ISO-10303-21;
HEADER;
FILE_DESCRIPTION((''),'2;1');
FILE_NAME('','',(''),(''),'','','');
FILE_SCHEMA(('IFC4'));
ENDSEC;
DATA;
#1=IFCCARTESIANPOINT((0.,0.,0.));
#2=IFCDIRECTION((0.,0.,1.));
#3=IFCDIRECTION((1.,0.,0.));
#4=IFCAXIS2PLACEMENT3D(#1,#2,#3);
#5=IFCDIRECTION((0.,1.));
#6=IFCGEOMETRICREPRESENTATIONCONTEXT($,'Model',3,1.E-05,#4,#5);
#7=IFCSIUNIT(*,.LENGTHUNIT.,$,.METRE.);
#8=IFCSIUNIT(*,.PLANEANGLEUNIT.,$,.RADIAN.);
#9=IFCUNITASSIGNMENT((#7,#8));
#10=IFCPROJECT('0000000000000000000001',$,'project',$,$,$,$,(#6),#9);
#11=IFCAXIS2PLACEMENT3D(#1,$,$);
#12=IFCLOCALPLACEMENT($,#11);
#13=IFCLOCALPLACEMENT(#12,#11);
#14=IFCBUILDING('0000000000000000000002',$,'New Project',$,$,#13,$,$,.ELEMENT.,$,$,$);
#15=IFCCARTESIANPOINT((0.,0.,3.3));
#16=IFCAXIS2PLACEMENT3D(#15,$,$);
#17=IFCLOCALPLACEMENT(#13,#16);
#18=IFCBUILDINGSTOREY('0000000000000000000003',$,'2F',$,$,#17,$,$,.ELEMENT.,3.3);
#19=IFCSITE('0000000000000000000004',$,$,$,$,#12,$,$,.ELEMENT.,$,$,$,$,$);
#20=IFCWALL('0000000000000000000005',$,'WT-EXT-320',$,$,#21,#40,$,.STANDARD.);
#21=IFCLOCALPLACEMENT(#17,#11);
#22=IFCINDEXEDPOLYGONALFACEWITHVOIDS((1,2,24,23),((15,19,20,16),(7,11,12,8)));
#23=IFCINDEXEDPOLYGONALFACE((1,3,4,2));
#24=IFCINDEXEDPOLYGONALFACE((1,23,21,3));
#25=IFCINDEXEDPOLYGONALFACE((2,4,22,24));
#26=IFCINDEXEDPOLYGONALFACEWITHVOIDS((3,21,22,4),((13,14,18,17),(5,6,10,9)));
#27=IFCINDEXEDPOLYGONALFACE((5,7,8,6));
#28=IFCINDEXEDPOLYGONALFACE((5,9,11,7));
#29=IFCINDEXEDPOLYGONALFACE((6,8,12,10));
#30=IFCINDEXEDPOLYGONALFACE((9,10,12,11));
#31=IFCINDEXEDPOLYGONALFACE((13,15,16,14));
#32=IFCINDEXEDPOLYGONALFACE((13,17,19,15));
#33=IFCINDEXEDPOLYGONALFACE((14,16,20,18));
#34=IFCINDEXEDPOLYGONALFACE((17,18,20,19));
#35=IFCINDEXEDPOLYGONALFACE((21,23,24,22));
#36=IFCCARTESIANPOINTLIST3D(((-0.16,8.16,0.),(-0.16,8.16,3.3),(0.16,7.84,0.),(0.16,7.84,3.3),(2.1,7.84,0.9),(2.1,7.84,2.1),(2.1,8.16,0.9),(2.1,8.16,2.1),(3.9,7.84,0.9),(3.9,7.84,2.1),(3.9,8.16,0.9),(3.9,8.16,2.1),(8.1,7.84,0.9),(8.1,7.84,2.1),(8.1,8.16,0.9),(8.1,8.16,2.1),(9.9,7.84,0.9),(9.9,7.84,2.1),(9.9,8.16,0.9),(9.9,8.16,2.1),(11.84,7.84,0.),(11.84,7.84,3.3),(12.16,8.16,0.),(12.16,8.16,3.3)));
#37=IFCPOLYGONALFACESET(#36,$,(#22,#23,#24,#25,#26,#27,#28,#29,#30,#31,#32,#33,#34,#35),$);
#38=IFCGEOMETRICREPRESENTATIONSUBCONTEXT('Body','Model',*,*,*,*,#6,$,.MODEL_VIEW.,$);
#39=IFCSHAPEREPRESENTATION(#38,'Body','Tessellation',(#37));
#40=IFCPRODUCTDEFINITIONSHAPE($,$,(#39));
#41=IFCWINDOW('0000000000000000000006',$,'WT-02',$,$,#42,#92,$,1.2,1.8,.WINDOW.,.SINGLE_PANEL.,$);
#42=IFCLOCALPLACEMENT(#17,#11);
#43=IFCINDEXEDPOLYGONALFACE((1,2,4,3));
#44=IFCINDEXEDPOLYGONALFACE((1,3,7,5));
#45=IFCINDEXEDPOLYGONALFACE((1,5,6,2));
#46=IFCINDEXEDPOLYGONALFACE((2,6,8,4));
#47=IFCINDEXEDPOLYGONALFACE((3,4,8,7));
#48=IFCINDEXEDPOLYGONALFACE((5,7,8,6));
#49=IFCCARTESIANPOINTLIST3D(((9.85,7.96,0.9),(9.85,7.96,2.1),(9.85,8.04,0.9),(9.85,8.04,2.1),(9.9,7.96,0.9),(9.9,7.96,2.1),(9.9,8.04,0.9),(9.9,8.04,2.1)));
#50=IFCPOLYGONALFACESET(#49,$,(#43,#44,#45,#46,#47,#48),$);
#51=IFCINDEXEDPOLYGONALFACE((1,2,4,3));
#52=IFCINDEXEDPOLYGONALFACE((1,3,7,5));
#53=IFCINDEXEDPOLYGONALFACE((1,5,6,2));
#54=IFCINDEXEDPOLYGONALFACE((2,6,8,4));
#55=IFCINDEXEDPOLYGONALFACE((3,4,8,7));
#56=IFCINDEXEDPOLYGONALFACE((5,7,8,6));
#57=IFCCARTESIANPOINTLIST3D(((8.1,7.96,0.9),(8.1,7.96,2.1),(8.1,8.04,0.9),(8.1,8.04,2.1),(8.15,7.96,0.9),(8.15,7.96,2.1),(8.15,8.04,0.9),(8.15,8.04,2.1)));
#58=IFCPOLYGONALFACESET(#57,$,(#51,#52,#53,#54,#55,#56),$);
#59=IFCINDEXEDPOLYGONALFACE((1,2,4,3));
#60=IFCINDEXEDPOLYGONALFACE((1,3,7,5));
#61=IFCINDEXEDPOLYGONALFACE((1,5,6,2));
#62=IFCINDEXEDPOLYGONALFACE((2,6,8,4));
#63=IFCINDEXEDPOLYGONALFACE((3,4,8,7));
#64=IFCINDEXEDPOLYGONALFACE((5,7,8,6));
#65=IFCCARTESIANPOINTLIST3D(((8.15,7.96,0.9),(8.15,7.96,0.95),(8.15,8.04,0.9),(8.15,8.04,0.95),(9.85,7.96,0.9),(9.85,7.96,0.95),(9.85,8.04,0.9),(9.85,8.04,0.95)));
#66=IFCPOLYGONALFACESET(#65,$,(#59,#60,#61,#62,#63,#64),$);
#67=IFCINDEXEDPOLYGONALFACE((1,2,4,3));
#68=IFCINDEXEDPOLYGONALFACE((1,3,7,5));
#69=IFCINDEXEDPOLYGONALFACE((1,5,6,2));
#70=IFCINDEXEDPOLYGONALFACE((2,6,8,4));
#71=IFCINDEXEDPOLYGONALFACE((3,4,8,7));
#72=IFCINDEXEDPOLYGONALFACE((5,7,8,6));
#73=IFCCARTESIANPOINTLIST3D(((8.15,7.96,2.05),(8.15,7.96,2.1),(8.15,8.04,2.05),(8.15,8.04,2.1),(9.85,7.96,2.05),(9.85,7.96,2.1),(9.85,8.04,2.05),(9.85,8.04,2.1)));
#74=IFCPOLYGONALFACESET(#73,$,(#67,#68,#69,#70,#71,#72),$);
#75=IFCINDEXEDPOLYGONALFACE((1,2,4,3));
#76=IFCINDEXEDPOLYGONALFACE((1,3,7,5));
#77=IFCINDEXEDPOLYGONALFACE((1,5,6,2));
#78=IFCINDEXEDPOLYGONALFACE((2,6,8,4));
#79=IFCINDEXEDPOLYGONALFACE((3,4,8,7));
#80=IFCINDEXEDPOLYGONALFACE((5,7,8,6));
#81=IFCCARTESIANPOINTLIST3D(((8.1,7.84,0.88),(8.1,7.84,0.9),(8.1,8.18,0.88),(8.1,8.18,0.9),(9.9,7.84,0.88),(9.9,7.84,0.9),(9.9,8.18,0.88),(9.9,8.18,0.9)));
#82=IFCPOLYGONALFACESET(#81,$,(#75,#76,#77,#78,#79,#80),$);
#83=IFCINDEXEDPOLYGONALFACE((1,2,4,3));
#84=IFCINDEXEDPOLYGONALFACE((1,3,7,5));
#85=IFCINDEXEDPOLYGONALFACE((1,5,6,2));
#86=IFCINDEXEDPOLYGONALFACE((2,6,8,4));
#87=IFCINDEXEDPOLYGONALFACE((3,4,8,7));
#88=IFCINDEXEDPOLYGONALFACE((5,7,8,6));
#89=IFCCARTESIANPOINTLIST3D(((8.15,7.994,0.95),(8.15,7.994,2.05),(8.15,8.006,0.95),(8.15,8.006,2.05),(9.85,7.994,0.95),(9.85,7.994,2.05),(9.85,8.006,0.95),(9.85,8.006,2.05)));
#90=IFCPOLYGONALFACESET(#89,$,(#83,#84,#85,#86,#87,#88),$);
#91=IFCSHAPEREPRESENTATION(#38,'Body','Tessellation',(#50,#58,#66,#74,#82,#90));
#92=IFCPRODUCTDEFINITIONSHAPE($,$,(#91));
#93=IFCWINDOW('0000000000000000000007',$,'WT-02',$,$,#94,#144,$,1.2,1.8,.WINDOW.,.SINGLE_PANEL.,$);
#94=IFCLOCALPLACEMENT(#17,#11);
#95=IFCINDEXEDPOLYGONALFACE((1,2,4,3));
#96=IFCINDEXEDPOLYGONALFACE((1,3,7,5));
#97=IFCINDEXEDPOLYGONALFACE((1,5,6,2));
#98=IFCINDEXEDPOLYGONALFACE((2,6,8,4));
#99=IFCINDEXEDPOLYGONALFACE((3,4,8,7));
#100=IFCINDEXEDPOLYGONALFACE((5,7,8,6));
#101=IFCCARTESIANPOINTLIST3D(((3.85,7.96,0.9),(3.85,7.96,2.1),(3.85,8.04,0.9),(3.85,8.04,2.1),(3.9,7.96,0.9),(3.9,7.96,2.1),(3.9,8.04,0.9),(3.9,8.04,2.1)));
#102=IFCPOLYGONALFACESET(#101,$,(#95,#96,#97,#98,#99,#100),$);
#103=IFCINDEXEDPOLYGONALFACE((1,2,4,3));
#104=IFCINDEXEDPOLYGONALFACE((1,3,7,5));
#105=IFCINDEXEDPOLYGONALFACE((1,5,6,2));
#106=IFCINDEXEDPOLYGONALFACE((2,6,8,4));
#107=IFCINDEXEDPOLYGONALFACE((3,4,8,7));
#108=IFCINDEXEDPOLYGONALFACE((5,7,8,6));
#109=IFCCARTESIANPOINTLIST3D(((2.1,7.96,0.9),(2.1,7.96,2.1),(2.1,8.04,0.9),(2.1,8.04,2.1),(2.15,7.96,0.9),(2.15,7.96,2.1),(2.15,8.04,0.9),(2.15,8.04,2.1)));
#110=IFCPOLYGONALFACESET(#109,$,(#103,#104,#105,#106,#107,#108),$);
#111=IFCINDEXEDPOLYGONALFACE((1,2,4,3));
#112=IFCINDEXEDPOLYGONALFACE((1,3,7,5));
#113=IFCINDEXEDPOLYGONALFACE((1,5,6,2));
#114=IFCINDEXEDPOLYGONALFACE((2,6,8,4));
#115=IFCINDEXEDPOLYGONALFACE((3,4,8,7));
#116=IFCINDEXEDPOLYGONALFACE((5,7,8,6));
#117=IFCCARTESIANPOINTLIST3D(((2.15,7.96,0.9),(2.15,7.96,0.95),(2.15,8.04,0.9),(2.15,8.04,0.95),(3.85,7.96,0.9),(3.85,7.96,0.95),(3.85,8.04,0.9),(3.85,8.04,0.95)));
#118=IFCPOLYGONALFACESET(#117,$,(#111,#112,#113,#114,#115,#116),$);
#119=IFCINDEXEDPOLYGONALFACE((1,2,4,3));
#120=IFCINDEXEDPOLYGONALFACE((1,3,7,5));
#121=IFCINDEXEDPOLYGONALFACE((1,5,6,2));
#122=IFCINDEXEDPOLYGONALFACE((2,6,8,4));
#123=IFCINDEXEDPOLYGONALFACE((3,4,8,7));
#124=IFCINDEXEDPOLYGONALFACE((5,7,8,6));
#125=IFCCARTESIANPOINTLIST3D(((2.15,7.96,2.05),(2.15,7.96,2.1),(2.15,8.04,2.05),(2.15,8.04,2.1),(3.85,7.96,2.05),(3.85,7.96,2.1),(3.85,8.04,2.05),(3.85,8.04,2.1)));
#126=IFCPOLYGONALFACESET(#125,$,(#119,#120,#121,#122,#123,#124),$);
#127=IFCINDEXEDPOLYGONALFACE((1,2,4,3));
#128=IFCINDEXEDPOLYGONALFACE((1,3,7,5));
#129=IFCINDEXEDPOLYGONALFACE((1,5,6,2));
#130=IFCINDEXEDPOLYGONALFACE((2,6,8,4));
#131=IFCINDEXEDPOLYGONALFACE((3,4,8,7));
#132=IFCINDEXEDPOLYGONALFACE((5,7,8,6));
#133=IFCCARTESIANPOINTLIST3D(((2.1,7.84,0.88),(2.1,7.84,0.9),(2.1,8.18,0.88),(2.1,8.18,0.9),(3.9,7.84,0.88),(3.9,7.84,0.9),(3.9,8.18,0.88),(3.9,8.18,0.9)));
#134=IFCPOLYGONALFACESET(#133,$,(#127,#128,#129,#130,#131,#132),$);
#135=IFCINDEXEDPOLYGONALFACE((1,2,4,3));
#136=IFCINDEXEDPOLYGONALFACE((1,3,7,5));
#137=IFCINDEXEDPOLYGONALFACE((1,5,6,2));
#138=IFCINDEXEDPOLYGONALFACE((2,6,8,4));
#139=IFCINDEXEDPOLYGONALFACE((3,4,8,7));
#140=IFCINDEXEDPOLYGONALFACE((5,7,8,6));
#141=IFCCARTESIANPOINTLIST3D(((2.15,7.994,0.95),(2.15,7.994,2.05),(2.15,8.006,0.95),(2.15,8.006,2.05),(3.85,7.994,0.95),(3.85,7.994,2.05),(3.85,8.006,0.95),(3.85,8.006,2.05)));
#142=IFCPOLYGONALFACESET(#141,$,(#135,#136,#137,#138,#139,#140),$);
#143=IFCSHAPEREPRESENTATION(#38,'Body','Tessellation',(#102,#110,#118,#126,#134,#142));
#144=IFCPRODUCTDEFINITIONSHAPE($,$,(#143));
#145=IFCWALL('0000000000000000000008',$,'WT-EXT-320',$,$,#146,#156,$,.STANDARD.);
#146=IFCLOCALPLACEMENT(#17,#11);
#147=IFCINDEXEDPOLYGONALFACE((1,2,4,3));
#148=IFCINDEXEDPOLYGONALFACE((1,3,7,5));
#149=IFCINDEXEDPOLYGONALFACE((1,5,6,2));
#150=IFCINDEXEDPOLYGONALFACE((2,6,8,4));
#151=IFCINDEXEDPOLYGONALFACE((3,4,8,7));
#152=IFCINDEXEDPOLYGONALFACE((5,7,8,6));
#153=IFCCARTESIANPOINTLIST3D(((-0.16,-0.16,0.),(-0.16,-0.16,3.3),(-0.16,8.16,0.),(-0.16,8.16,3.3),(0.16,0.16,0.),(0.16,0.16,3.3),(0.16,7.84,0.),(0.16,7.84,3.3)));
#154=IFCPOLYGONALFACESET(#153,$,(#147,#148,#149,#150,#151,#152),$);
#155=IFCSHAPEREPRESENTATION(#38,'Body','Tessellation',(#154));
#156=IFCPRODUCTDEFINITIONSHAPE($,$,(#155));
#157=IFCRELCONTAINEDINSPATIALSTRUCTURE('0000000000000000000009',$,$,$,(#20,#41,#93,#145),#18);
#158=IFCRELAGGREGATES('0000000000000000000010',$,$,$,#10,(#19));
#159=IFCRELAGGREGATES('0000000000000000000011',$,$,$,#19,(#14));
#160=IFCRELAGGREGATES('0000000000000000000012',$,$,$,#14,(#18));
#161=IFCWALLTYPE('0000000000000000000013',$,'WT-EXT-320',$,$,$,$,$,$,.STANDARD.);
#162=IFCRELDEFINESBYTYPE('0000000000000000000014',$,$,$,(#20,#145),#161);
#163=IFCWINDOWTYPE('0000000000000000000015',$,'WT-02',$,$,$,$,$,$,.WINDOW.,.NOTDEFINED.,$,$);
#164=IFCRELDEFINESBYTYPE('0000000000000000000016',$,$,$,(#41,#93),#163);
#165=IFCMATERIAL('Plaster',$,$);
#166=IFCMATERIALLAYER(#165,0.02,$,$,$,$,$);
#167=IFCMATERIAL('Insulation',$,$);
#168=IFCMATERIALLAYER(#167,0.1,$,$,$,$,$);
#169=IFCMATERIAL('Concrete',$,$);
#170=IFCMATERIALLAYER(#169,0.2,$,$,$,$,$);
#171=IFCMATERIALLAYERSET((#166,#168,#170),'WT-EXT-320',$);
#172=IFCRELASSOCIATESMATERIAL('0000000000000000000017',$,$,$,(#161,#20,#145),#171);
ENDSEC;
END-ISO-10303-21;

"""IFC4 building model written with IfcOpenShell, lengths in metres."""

from ifc_helpers import new_model, si_unit, direction, frame, frame_2d, origin, origin_with_axes, place, context, subcontext, project, spatial, polyline, rectangle, outline, extrude, material, layer, layer_set, layer_usage, type_object, element, fill, save


model = new_model("IFC4")

# Units and contexts
model_context = context("Model", 3, precision=1e-05, world=origin_with_axes(), true_north=direction((0.0, 1.0)))
body_context = subcontext(model_context, "Body", "Model", "MODEL_VIEW")
ifc_project = project(units=[si_unit("LENGTHUNIT", "METRE"), si_unit("PLANEANGLEUNIT", "RADIAN")], contexts=[model_context])

# Site, building, storey
site_placement = place(None, origin())
site = spatial("IfcSite", under=ifc_project, at=site_placement, CompositionType="ELEMENT")
building_placement = place(site_placement, origin())
building = spatial("IfcBuilding", under=site, at=building_placement, Name="New Project", CompositionType="ELEMENT")
storey_placement = place(building_placement, frame((0.0, 0.0, 3.3)))
storey = spatial("IfcBuildingStorey", under=building, at=storey_placement, Name="2F", CompositionType="ELEMENT", Elevation=3.3)

# Shared definitions
ifc_material_1 = material(Name="Concrete")

# Shared definitions
ifc_material_2 = material(Name="Plaster")
ifc_layer_1 = layer(ifc_material_2, 0.02)
ifc_material_3 = material(Name="Insulation")
ifc_layer_2 = layer(ifc_material_3, 0.1)
ifc_layer_3 = layer(ifc_material_1, 0.2)
ifc_layer_set_1 = layer_set([ifc_layer_1, ifc_layer_2, ifc_layer_3], Name="WT-EXT-320")
ifc_layer_usage_1 = layer_usage(ifc_layer_set_1, "AXIS2", "NEGATIVE", 0.16)
wall_type_1 = type_object("IfcWallType", Name="WT-EXT-320", PredefinedType="STANDARD", material=ifc_layer_set_1)

# Wall, openings, windows
wall_1_placement = place(storey_placement, frame((12.0, 8.0, 0.0), z_axis=(0.0, 0.0, 1.0), x_axis=(-1.0, 0.0, 0.0)))
wall_1 = element("IfcWall", 1, at=wall_1_placement, inside=storey, type_object=wall_type_1, material=ifc_layer_usage_1, Name="WT-EXT-320", PredefinedType="STANDARD", context=body_context, shape_type="SweptSolid", body=[
    extrude(outline(polyline([(-0.16, -0.16), (12.16, -0.16), (11.84, 0.16), (0.16, 0.16), (-0.16, -0.16)])), origin(), (0.0, 0.0, 1.0), 3.3),
])
opening_1_placement = place(wall_1_placement, frame((2.1, 0.0, 0.9)))
opening_1 = element("IfcOpeningElement", 2, at=opening_1_placement, cuts=wall_1, PredefinedType="OPENING", context=body_context, shape_type="SweptSolid", body=[
    extrude(rectangle(XDim=1.8, YDim=0.42, at=frame_2d((0.9, 0.0))), origin(), (0.0, 0.0, 1.0), 1.2),
])
opening_2_placement = place(wall_1_placement, frame((8.1, 0.0, 0.9)))
opening_2 = element("IfcOpeningElement", 3, at=opening_2_placement, cuts=wall_1, PredefinedType="OPENING", context=body_context, shape_type="SweptSolid", body=[
    extrude(rectangle(XDim=1.8, YDim=0.42, at=frame_2d((0.9, 0.0))), origin(), (0.0, 0.0, 1.0), 1.2),
])
window_type_1 = type_object("IfcWindowType", Name="WT-02", PartitioningType="NOTDEFINED", PredefinedType="WINDOW")
window_1_placement = place(opening_1_placement, origin())
window_1 = element("IfcWindow", 4, at=window_1_placement, inside=storey, type_object=window_type_1, Name="WT-02", OverallHeight=1.2, OverallWidth=1.8, PartitioningType="SINGLE_PANEL", PredefinedType="WINDOW", context=body_context, shape_type="SweptSolid", body=[
    extrude(outline(polyline([(0.0, -0.04), (0.05, -0.04), (0.05, 0.04), (0.0, 0.04), (0.0, -0.04)])), origin(), (0.0, 0.0, 1.0), 1.2),
    extrude(outline(polyline([(1.75, -0.04), (1.8, -0.04), (1.8, 0.04), (1.75, 0.04), (1.75, -0.04)])), origin(), (0.0, 0.0, 1.0), 1.2),
    extrude(outline(polyline([(0.05, -0.04), (1.75, -0.04), (1.75, 0.04), (0.05, 0.04), (0.05, -0.04)])), origin(), (0.0, 0.0, 1.0), 0.05),
    extrude(outline(polyline([(0.05, -0.04), (1.75, -0.04), (1.75, 0.04), (0.05, 0.04), (0.05, -0.04)])), frame((0.0, 0.0, 1.15)), (0.0, 0.0, 1.0), 0.05),
    extrude(outline(polyline([(0.0, -0.18), (1.8, -0.18), (1.8, 0.16), (0.0, 0.16), (0.0, -0.18)])), frame((0.0, 0.0, -0.02)), (0.0, 0.0, 1.0), 0.02),
    extrude(outline(polyline([(0.05, -0.006), (1.75, -0.006), (1.75, 0.006), (0.05, 0.006), (0.05, -0.006)])), frame((0.0, 0.0, 0.05)), (0.0, 0.0, 1.0), 1.1),
])
fill(opening_1, window_1)
window_2_placement = place(opening_2_placement, origin())
window_2 = element("IfcWindow", 5, at=window_2_placement, inside=storey, type_object=window_type_1, Name="WT-02", OverallHeight=1.2, OverallWidth=1.8, PartitioningType="SINGLE_PANEL", PredefinedType="WINDOW", context=body_context, shape_type="SweptSolid", body=[
    extrude(outline(polyline([(0.0, -0.04), (0.05, -0.04), (0.05, 0.04), (0.0, 0.04), (0.0, -0.04)])), origin(), (0.0, 0.0, 1.0), 1.2),
    extrude(outline(polyline([(1.75, -0.04), (1.8, -0.04), (1.8, 0.04), (1.75, 0.04), (1.75, -0.04)])), origin(), (0.0, 0.0, 1.0), 1.2),
    extrude(outline(polyline([(0.05, -0.04), (1.75, -0.04), (1.75, 0.04), (0.05, 0.04), (0.05, -0.04)])), origin(), (0.0, 0.0, 1.0), 0.05),
    extrude(outline(polyline([(0.05, -0.04), (1.75, -0.04), (1.75, 0.04), (0.05, 0.04), (0.05, -0.04)])), frame((0.0, 0.0, 1.15)), (0.0, 0.0, 1.0), 0.05),
    extrude(outline(polyline([(0.0, -0.18), (1.8, -0.18), (1.8, 0.16), (0.0, 0.16), (0.0, -0.18)])), frame((0.0, 0.0, -0.02)), (0.0, 0.0, 1.0), 0.02),
    extrude(outline(polyline([(0.05, -0.006), (1.75, -0.006), (1.75, 0.006), (0.05, 0.006), (0.05, -0.006)])), frame((0.0, 0.0, 0.05)), (0.0, 0.0, 1.0), 1.1),
])
fill(opening_2, window_2)

# Wall
wall_2_placement = place(storey_placement, frame((0.0, 8.0, 0.0), z_axis=(0.0, 0.0, 1.0), x_axis=(0.0, -1.0, 0.0)))
element("IfcWall", 6, at=wall_2_placement, inside=storey, type_object=wall_type_1, material=ifc_layer_usage_1, Name="WT-EXT-320", PredefinedType="STANDARD", context=body_context, shape_type="SweptSolid", body=[
    extrude(outline(polyline([(-0.16, -0.16), (8.16, -0.16), (7.84, 0.16), (0.16, 0.16), (-0.16, -0.16)])), origin(), (0.0, 0.0, 1.0), 3.3),
])

save(model, "model.ifc")
